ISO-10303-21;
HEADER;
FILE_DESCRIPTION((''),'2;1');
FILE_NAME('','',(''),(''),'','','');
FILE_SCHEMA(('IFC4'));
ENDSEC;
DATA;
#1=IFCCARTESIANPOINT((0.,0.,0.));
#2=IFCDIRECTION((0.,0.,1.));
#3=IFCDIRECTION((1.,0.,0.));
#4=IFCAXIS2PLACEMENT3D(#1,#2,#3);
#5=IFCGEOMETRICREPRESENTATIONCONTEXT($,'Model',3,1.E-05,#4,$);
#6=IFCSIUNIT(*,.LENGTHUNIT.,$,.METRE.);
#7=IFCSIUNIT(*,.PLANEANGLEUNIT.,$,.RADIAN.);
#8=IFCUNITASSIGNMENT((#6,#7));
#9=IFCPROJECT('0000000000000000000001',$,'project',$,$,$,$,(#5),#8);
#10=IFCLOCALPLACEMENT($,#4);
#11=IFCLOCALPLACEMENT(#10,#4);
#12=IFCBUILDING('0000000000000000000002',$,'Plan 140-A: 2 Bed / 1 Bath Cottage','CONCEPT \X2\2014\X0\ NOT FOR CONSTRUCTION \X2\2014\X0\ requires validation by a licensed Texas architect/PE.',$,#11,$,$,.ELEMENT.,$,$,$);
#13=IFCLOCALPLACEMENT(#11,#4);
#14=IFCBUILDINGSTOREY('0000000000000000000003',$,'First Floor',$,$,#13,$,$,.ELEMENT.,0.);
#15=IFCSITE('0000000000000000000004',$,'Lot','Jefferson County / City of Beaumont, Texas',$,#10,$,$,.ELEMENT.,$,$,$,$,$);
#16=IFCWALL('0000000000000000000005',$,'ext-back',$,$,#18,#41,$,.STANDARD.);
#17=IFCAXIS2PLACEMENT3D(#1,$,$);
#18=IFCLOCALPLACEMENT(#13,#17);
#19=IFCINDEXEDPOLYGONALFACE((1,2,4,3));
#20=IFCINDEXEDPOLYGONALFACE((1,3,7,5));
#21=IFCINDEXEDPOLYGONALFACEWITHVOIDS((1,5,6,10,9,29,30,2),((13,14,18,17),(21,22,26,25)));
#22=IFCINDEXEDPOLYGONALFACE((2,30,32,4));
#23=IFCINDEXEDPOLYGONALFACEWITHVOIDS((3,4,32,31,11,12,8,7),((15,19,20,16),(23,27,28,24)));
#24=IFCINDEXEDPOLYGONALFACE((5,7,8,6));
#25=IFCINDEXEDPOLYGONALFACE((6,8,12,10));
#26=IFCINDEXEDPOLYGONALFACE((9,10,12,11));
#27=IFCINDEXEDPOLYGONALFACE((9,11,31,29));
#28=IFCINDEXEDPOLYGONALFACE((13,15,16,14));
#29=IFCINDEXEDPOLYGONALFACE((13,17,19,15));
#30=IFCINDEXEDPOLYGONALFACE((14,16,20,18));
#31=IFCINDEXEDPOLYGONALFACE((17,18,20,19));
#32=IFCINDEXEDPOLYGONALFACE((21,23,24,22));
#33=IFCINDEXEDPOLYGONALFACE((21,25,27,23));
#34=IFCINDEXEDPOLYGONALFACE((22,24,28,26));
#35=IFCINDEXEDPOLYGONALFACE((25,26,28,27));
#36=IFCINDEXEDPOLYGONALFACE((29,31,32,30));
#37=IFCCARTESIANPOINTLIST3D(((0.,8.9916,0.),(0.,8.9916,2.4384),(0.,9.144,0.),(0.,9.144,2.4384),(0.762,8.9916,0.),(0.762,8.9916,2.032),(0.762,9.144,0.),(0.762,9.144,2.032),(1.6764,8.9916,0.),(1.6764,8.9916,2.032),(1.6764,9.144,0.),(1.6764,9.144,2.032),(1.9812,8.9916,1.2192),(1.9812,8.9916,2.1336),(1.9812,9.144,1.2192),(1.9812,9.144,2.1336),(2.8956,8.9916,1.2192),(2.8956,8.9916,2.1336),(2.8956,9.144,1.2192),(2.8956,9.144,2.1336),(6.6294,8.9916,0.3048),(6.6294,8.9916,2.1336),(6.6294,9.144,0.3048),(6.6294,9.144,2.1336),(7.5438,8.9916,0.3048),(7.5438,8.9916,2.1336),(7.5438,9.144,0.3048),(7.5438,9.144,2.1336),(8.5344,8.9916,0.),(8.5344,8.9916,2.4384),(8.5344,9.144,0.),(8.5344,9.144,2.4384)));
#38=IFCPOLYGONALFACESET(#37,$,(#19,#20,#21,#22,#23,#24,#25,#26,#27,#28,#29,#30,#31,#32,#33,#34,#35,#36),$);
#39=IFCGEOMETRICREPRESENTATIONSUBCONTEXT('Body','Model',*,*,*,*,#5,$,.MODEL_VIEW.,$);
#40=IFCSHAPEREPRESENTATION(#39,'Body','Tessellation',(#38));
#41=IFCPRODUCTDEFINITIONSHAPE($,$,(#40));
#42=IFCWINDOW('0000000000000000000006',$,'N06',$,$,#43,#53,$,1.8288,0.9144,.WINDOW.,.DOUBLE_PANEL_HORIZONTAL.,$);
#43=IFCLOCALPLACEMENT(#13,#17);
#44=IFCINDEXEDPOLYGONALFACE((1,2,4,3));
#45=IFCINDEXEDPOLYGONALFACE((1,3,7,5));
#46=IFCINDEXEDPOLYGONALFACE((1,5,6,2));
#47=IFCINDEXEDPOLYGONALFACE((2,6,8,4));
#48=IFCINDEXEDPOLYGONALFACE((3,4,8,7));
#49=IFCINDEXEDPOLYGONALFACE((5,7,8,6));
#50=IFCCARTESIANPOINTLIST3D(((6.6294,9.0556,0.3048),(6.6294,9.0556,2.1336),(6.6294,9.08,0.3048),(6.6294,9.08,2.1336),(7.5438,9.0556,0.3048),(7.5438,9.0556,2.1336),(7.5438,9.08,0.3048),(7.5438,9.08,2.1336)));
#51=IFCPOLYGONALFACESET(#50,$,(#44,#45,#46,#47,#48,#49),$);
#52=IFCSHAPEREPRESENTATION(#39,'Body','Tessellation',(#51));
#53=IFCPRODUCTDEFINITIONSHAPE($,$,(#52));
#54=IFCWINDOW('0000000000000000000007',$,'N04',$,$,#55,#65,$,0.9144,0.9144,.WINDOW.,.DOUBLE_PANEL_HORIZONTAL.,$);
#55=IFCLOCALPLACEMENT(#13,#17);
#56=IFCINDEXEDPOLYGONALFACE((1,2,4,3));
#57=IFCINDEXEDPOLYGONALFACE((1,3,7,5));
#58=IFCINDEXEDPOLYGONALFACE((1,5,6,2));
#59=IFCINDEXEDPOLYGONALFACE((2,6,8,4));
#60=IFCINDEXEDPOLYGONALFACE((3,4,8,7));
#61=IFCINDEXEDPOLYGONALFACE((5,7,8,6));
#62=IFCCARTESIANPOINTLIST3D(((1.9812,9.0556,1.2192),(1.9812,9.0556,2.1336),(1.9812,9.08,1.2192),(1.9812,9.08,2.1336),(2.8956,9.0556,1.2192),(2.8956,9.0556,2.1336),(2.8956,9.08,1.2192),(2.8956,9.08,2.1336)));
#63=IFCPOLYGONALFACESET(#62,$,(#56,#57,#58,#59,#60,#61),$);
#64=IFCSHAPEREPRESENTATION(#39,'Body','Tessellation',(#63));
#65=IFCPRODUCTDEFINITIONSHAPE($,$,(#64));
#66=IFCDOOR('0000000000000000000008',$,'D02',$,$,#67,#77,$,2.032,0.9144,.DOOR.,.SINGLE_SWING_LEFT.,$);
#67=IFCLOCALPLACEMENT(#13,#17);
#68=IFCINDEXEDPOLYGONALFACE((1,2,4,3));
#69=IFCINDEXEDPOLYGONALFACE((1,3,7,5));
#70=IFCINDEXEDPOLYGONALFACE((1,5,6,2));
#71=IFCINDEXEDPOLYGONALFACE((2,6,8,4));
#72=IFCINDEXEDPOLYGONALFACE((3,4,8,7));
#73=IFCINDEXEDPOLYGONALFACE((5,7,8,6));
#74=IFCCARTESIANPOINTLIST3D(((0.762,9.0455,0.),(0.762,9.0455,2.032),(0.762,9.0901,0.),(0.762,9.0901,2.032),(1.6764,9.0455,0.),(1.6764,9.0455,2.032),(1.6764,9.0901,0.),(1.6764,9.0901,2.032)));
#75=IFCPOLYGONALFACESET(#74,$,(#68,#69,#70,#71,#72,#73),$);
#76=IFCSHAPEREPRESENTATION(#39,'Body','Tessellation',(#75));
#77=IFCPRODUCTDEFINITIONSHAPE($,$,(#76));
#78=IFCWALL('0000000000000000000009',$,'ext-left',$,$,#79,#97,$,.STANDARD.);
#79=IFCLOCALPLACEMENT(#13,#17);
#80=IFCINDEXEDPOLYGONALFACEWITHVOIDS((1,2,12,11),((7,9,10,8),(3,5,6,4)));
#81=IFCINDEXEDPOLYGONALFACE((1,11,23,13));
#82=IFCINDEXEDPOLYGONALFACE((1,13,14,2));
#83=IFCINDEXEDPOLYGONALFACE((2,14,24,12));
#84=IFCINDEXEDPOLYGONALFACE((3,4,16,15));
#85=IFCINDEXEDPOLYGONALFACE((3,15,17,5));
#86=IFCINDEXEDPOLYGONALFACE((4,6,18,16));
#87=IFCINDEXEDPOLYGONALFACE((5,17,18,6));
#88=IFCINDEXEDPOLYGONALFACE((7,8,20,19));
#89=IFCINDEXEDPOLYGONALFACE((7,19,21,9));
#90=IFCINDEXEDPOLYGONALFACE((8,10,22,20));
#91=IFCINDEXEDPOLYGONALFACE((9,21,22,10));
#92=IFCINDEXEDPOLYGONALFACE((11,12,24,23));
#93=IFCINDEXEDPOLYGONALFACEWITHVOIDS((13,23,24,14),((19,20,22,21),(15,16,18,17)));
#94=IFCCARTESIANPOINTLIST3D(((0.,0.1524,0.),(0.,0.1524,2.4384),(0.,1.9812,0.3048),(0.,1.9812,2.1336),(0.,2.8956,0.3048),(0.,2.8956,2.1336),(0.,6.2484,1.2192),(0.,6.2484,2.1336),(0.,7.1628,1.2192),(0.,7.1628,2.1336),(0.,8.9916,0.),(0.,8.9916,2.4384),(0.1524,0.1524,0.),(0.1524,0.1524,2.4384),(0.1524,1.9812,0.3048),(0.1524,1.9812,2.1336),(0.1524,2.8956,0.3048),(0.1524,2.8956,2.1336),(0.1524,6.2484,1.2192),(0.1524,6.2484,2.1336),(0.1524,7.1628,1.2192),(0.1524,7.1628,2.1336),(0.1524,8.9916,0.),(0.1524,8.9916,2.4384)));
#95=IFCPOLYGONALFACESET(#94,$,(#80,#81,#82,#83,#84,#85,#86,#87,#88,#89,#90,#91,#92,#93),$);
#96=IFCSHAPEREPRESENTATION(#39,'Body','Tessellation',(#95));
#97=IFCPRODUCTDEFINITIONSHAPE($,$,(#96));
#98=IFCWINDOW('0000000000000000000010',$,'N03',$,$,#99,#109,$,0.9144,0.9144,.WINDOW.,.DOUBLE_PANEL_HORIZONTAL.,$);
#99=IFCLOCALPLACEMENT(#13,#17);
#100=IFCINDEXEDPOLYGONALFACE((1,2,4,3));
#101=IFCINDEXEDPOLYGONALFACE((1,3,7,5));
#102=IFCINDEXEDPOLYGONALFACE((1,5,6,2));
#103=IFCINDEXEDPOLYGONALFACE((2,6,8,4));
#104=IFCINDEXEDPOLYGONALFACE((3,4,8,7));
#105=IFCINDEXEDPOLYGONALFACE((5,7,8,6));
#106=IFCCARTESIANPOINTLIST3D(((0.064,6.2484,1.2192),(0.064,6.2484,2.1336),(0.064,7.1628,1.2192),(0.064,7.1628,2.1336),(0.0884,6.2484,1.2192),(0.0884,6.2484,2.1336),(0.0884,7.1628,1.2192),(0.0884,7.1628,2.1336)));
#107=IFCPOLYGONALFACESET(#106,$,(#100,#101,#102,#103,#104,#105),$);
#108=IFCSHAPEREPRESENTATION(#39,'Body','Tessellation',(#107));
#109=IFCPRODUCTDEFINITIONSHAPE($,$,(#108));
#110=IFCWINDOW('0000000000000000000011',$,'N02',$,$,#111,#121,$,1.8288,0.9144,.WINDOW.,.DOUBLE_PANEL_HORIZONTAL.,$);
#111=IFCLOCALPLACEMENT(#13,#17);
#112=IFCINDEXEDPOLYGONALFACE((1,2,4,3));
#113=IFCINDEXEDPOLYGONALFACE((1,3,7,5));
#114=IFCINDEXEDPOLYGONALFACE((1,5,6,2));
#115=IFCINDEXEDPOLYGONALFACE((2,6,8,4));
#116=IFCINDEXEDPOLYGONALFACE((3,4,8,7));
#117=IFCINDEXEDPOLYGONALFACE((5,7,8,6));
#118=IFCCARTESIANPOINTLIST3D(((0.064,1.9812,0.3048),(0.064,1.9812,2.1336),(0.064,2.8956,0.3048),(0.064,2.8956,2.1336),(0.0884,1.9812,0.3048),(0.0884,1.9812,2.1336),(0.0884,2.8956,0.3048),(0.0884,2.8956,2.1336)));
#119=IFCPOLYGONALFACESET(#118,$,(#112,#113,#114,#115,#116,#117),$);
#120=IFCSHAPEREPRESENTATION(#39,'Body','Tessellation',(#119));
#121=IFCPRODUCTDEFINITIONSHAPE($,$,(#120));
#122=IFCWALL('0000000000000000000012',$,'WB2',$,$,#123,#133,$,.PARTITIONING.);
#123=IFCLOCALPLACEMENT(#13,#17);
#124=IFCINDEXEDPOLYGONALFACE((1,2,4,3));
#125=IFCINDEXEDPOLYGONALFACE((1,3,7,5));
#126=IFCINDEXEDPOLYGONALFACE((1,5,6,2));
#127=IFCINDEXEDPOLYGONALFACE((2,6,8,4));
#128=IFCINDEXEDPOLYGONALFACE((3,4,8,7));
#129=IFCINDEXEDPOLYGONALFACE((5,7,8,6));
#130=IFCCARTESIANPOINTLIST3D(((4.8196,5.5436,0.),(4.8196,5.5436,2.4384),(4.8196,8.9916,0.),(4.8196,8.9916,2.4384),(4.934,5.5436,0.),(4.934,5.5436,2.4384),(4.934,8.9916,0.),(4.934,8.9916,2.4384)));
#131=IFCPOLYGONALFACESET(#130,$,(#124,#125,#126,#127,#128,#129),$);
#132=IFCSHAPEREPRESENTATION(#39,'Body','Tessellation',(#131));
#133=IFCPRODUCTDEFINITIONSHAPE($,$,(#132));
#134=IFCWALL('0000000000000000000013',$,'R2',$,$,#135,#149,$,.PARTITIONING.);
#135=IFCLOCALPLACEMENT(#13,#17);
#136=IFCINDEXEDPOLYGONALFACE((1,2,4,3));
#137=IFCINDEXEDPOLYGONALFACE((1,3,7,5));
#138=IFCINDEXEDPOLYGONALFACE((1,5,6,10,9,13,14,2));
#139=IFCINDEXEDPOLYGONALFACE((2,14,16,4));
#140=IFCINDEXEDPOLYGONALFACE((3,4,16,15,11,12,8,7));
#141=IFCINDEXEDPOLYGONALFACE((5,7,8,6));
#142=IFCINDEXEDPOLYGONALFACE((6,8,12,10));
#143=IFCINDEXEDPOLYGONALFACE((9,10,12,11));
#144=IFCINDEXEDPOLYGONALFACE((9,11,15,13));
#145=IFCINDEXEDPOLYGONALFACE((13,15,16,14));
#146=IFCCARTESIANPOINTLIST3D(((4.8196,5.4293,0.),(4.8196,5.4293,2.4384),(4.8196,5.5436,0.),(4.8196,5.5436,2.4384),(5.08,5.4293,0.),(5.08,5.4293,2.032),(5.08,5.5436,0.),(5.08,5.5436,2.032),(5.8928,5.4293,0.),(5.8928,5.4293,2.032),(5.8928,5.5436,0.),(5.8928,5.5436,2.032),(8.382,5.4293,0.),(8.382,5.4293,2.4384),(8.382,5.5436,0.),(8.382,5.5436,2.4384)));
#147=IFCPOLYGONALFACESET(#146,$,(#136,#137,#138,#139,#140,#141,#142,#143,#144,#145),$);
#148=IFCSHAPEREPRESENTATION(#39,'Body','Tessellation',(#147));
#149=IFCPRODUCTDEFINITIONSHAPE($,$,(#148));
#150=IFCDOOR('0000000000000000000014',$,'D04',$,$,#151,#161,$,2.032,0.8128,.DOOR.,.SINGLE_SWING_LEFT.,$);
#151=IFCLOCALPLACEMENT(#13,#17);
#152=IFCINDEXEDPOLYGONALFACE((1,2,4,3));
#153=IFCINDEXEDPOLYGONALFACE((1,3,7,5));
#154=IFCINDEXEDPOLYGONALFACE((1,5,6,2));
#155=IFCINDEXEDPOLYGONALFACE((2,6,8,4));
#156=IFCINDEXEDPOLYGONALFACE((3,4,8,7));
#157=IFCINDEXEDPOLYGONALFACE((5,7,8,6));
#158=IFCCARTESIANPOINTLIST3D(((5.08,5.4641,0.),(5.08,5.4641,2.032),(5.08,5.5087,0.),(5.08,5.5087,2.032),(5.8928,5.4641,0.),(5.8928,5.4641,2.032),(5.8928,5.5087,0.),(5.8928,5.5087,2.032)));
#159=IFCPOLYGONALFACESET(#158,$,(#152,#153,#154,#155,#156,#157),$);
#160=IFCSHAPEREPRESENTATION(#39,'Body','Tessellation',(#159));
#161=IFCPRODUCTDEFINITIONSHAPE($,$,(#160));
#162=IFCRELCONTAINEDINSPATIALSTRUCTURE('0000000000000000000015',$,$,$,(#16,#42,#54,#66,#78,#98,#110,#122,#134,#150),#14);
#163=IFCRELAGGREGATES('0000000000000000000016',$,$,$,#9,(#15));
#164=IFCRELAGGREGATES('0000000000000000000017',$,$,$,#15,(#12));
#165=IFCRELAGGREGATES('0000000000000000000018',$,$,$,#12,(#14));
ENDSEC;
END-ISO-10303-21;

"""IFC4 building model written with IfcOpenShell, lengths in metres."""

from ifc_helpers import new_model, si_unit, frame, frame_2d, origin_with_axes, place, context, subcontext, project, spatial, rectangle, extrude, element, fill, save


model = new_model("IFC4")

# Units and contexts
model_context = context("Model", 3, precision=1e-05, world=origin_with_axes())
body_context = subcontext(model_context, "Body", "Model", "MODEL_VIEW")
ifc_project = project(units=[si_unit("LENGTHUNIT", "METRE"), si_unit("PLANEANGLEUNIT", "RADIAN")], contexts=[model_context])

# Site, building, storey
site_placement = place(None, origin_with_axes())
site = spatial("IfcSite", under=ifc_project, at=site_placement, Name="Lot", Description="Jefferson County / City of Beaumont, Texas", CompositionType="ELEMENT")
building_placement = place(site_placement, origin_with_axes())
building = spatial("IfcBuilding", under=site, at=building_placement, Name="Plan 140-A: 2 Bed / 1 Bath Cottage", Description="CONCEPT — NOT FOR CONSTRUCTION — requires validation by a licensed Texas architect/PE.", CompositionType="ELEMENT")
storey_placement = place(building_placement, origin_with_axes())
storey = spatial("IfcBuildingStorey", under=building, at=storey_placement, Name="First Floor", CompositionType="ELEMENT", Elevation=0.0)

# Wall, openings, windows, door
wall_1_placement = place(storey_placement, frame((8.5344, 9.0678, 0.0), z_axis=(0.0, 0.0, 1.0), x_axis=(-1.0, 0.0, 0.0)))
wall_1 = element("IfcWall", 1, at=wall_1_placement, inside=storey, Name="ext-back", PredefinedType="STANDARD", context=body_context, shape_type="SweptSolid", body=[
    extrude(rectangle(XDim=8.5344, YDim=0.1524, at=frame_2d((4.2672, 0.0), x_axis=(1.0, 0.0))), origin_with_axes(), (0.0, 0.0, 1.0), 2.4384),
])
opening_1_placement = place(wall_1_placement, frame((0.9906, 0.0, 0.3048), z_axis=(0.0, 0.0, 1.0), x_axis=(1.0, 0.0, 0.0)))
opening_1 = element("IfcOpeningElement", 2, at=opening_1_placement, cuts=wall_1, PredefinedType="OPENING", context=body_context, shape_type="SweptSolid", body=[
    extrude(rectangle(XDim=0.9144, YDim=0.1829, at=frame_2d((0.4572, 0.0), x_axis=(1.0, 0.0))), origin_with_axes(), (0.0, 0.0, 1.0), 1.8288),
])
opening_2_placement = place(wall_1_placement, frame((5.6388, 0.0, 1.2192), z_axis=(0.0, 0.0, 1.0), x_axis=(1.0, 0.0, 0.0)))
opening_2 = element("IfcOpeningElement", 3, at=opening_2_placement, cuts=wall_1, PredefinedType="OPENING", context=body_context, shape_type="SweptSolid", body=[
    extrude(rectangle(XDim=0.9144, YDim=0.1829, at=frame_2d((0.4572, 0.0), x_axis=(1.0, 0.0))), origin_with_axes(), (0.0, 0.0, 1.0), 0.9144),
])
opening_3_placement = place(wall_1_placement, frame((6.858, 0.0, 0.0), z_axis=(0.0, 0.0, 1.0), x_axis=(1.0, 0.0, 0.0)))
opening_3 = element("IfcOpeningElement", 4, at=opening_3_placement, cuts=wall_1, PredefinedType="OPENING", context=body_context, shape_type="SweptSolid", body=[
    extrude(rectangle(XDim=0.9144, YDim=0.1829, at=frame_2d((0.4572, 0.0), x_axis=(1.0, 0.0))), origin_with_axes(), (0.0, 0.0, 1.0), 2.032),
])
window_1_placement = place(opening_1_placement, origin_with_axes())
window_1 = element("IfcWindow", 5, at=window_1_placement, inside=storey, Name="N06", OverallHeight=1.8288, OverallWidth=0.9144, PartitioningType="DOUBLE_PANEL_HORIZONTAL", PredefinedType="WINDOW", context=body_context, shape_type="SweptSolid", body=[
    extrude(rectangle(XDim=0.9144, YDim=0.0244, at=frame_2d((0.4572, 0.0), x_axis=(1.0, 0.0))), origin_with_axes(), (0.0, 0.0, 1.0), 1.8288),
])
fill(opening_1, window_1)
window_2_placement = place(opening_2_placement, origin_with_axes())
window_2 = element("IfcWindow", 6, at=window_2_placement, inside=storey, Name="N04", OverallHeight=0.9144, OverallWidth=0.9144, PartitioningType="DOUBLE_PANEL_HORIZONTAL", PredefinedType="WINDOW", context=body_context, shape_type="SweptSolid", body=[
    extrude(rectangle(XDim=0.9144, YDim=0.0244, at=frame_2d((0.4572, 0.0), x_axis=(1.0, 0.0))), origin_with_axes(), (0.0, 0.0, 1.0), 0.9144),
])
fill(opening_2, window_2)
door_1_placement = place(opening_3_placement, origin_with_axes())
door_1 = element("IfcDoor", 7, at=door_1_placement, inside=storey, Name="D02", OperationType="SINGLE_SWING_LEFT", OverallHeight=2.032, OverallWidth=0.9144, PredefinedType="DOOR", context=body_context, shape_type="SweptSolid", body=[
    extrude(rectangle(XDim=0.9144, YDim=0.0445, at=frame_2d((0.4572, 0.0), x_axis=(1.0, 0.0))), origin_with_axes(), (0.0, 0.0, 1.0), 2.032),
])
fill(opening_3, door_1)

# Wall, openings, windows
wall_2_placement = place(storey_placement, frame((0.0762, 8.9916, 0.0), z_axis=(0.0, 0.0, 1.0), x_axis=(0.0, -1.0, 0.0)))
wall_2 = element("IfcWall", 8, at=wall_2_placement, inside=storey, Name="ext-left", PredefinedType="STANDARD", context=body_context, shape_type="SweptSolid", body=[
    extrude(rectangle(XDim=8.8392, YDim=0.1524, at=frame_2d((4.4196, 0.0), x_axis=(1.0, 0.0))), origin_with_axes(), (0.0, 0.0, 1.0), 2.4384),
])
opening_4_placement = place(wall_2_placement, frame((1.8288, 0.0, 1.2192), z_axis=(0.0, 0.0, 1.0), x_axis=(1.0, 0.0, 0.0)))
opening_4 = element("IfcOpeningElement", 9, at=opening_4_placement, cuts=wall_2, PredefinedType="OPENING", context=body_context, shape_type="SweptSolid", body=[
    extrude(rectangle(XDim=0.9144, YDim=0.1829, at=frame_2d((0.4572, 0.0), x_axis=(1.0, 0.0))), origin_with_axes(), (0.0, 0.0, 1.0), 0.9144),
])
opening_5_placement = place(wall_2_placement, frame((6.096, 0.0, 0.3048), z_axis=(0.0, 0.0, 1.0), x_axis=(1.0, 0.0, 0.0)))
opening_5 = element("IfcOpeningElement", 10, at=opening_5_placement, cuts=wall_2, PredefinedType="OPENING", context=body_context, shape_type="SweptSolid", body=[
    extrude(rectangle(XDim=0.9144, YDim=0.1829, at=frame_2d((0.4572, 0.0), x_axis=(1.0, 0.0))), origin_with_axes(), (0.0, 0.0, 1.0), 1.8288),
])
window_3_placement = place(opening_4_placement, origin_with_axes())
window_3 = element("IfcWindow", 11, at=window_3_placement, inside=storey, Name="N03", OverallHeight=0.9144, OverallWidth=0.9144, PartitioningType="DOUBLE_PANEL_HORIZONTAL", PredefinedType="WINDOW", context=body_context, shape_type="SweptSolid", body=[
    extrude(rectangle(XDim=0.9144, YDim=0.0244, at=frame_2d((0.4572, 0.0), x_axis=(1.0, 0.0))), origin_with_axes(), (0.0, 0.0, 1.0), 0.9144),
])
fill(opening_4, window_3)
window_4_placement = place(opening_5_placement, origin_with_axes())
window_4 = element("IfcWindow", 12, at=window_4_placement, inside=storey, Name="N02", OverallHeight=1.8288, OverallWidth=0.9144, PartitioningType="DOUBLE_PANEL_HORIZONTAL", PredefinedType="WINDOW", context=body_context, shape_type="SweptSolid", body=[
    extrude(rectangle(XDim=0.9144, YDim=0.0244, at=frame_2d((0.4572, 0.0), x_axis=(1.0, 0.0))), origin_with_axes(), (0.0, 0.0, 1.0), 1.8288),
])
fill(opening_5, window_4)

# Wall
wall_3_placement = place(storey_placement, frame((4.8768, 5.5436, 0.0), z_axis=(0.0, 0.0, 1.0), x_axis=(0.0, 1.0, 0.0)))
element("IfcWall", 13, at=wall_3_placement, inside=storey, Name="WB2", PredefinedType="PARTITIONING", context=body_context, shape_type="SweptSolid", body=[
    extrude(rectangle(XDim=3.4481, YDim=0.1143, at=frame_2d((1.724, 0.0), x_axis=(1.0, 0.0))), origin_with_axes(), (0.0, 0.0, 1.0), 2.4384),
])

# Wall, opening, door
wall_4_placement = place(storey_placement, frame((4.8197, 5.4864, 0.0), z_axis=(0.0, 0.0, 1.0), x_axis=(1.0, 0.0, 0.0)))
wall_4 = element("IfcWall", 14, at=wall_4_placement, inside=storey, Name="R2", PredefinedType="PARTITIONING", context=body_context, shape_type="SweptSolid", body=[
    extrude(rectangle(XDim=3.5624, YDim=0.1143, at=frame_2d((1.7812, 0.0), x_axis=(1.0, 0.0))), origin_with_axes(), (0.0, 0.0, 1.0), 2.4384),
])
opening_6_placement = place(wall_4_placement, frame((0.2603, 0.0, 0.0), z_axis=(0.0, 0.0, 1.0), x_axis=(1.0, 0.0, 0.0)))
opening_6 = element("IfcOpeningElement", 15, at=opening_6_placement, cuts=wall_4, PredefinedType="OPENING", context=body_context, shape_type="SweptSolid", body=[
    extrude(rectangle(XDim=0.8128, YDim=0.1448, at=frame_2d((0.4064, 0.0), x_axis=(1.0, 0.0))), origin_with_axes(), (0.0, 0.0, 1.0), 2.032),
])
door_2_placement = place(opening_6_placement, origin_with_axes())
door_2 = element("IfcDoor", 16, at=door_2_placement, inside=storey, Name="D04", OperationType="SINGLE_SWING_LEFT", OverallHeight=2.032, OverallWidth=0.8128, PredefinedType="DOOR", context=body_context, shape_type="SweptSolid", body=[
    extrude(rectangle(XDim=0.8128, YDim=0.0445, at=frame_2d((0.4064, 0.0), x_axis=(1.0, 0.0))), origin_with_axes(), (0.0, 0.0, 1.0), 2.032),
])
fill(opening_6, door_2)

save(model, "model.ifc")
